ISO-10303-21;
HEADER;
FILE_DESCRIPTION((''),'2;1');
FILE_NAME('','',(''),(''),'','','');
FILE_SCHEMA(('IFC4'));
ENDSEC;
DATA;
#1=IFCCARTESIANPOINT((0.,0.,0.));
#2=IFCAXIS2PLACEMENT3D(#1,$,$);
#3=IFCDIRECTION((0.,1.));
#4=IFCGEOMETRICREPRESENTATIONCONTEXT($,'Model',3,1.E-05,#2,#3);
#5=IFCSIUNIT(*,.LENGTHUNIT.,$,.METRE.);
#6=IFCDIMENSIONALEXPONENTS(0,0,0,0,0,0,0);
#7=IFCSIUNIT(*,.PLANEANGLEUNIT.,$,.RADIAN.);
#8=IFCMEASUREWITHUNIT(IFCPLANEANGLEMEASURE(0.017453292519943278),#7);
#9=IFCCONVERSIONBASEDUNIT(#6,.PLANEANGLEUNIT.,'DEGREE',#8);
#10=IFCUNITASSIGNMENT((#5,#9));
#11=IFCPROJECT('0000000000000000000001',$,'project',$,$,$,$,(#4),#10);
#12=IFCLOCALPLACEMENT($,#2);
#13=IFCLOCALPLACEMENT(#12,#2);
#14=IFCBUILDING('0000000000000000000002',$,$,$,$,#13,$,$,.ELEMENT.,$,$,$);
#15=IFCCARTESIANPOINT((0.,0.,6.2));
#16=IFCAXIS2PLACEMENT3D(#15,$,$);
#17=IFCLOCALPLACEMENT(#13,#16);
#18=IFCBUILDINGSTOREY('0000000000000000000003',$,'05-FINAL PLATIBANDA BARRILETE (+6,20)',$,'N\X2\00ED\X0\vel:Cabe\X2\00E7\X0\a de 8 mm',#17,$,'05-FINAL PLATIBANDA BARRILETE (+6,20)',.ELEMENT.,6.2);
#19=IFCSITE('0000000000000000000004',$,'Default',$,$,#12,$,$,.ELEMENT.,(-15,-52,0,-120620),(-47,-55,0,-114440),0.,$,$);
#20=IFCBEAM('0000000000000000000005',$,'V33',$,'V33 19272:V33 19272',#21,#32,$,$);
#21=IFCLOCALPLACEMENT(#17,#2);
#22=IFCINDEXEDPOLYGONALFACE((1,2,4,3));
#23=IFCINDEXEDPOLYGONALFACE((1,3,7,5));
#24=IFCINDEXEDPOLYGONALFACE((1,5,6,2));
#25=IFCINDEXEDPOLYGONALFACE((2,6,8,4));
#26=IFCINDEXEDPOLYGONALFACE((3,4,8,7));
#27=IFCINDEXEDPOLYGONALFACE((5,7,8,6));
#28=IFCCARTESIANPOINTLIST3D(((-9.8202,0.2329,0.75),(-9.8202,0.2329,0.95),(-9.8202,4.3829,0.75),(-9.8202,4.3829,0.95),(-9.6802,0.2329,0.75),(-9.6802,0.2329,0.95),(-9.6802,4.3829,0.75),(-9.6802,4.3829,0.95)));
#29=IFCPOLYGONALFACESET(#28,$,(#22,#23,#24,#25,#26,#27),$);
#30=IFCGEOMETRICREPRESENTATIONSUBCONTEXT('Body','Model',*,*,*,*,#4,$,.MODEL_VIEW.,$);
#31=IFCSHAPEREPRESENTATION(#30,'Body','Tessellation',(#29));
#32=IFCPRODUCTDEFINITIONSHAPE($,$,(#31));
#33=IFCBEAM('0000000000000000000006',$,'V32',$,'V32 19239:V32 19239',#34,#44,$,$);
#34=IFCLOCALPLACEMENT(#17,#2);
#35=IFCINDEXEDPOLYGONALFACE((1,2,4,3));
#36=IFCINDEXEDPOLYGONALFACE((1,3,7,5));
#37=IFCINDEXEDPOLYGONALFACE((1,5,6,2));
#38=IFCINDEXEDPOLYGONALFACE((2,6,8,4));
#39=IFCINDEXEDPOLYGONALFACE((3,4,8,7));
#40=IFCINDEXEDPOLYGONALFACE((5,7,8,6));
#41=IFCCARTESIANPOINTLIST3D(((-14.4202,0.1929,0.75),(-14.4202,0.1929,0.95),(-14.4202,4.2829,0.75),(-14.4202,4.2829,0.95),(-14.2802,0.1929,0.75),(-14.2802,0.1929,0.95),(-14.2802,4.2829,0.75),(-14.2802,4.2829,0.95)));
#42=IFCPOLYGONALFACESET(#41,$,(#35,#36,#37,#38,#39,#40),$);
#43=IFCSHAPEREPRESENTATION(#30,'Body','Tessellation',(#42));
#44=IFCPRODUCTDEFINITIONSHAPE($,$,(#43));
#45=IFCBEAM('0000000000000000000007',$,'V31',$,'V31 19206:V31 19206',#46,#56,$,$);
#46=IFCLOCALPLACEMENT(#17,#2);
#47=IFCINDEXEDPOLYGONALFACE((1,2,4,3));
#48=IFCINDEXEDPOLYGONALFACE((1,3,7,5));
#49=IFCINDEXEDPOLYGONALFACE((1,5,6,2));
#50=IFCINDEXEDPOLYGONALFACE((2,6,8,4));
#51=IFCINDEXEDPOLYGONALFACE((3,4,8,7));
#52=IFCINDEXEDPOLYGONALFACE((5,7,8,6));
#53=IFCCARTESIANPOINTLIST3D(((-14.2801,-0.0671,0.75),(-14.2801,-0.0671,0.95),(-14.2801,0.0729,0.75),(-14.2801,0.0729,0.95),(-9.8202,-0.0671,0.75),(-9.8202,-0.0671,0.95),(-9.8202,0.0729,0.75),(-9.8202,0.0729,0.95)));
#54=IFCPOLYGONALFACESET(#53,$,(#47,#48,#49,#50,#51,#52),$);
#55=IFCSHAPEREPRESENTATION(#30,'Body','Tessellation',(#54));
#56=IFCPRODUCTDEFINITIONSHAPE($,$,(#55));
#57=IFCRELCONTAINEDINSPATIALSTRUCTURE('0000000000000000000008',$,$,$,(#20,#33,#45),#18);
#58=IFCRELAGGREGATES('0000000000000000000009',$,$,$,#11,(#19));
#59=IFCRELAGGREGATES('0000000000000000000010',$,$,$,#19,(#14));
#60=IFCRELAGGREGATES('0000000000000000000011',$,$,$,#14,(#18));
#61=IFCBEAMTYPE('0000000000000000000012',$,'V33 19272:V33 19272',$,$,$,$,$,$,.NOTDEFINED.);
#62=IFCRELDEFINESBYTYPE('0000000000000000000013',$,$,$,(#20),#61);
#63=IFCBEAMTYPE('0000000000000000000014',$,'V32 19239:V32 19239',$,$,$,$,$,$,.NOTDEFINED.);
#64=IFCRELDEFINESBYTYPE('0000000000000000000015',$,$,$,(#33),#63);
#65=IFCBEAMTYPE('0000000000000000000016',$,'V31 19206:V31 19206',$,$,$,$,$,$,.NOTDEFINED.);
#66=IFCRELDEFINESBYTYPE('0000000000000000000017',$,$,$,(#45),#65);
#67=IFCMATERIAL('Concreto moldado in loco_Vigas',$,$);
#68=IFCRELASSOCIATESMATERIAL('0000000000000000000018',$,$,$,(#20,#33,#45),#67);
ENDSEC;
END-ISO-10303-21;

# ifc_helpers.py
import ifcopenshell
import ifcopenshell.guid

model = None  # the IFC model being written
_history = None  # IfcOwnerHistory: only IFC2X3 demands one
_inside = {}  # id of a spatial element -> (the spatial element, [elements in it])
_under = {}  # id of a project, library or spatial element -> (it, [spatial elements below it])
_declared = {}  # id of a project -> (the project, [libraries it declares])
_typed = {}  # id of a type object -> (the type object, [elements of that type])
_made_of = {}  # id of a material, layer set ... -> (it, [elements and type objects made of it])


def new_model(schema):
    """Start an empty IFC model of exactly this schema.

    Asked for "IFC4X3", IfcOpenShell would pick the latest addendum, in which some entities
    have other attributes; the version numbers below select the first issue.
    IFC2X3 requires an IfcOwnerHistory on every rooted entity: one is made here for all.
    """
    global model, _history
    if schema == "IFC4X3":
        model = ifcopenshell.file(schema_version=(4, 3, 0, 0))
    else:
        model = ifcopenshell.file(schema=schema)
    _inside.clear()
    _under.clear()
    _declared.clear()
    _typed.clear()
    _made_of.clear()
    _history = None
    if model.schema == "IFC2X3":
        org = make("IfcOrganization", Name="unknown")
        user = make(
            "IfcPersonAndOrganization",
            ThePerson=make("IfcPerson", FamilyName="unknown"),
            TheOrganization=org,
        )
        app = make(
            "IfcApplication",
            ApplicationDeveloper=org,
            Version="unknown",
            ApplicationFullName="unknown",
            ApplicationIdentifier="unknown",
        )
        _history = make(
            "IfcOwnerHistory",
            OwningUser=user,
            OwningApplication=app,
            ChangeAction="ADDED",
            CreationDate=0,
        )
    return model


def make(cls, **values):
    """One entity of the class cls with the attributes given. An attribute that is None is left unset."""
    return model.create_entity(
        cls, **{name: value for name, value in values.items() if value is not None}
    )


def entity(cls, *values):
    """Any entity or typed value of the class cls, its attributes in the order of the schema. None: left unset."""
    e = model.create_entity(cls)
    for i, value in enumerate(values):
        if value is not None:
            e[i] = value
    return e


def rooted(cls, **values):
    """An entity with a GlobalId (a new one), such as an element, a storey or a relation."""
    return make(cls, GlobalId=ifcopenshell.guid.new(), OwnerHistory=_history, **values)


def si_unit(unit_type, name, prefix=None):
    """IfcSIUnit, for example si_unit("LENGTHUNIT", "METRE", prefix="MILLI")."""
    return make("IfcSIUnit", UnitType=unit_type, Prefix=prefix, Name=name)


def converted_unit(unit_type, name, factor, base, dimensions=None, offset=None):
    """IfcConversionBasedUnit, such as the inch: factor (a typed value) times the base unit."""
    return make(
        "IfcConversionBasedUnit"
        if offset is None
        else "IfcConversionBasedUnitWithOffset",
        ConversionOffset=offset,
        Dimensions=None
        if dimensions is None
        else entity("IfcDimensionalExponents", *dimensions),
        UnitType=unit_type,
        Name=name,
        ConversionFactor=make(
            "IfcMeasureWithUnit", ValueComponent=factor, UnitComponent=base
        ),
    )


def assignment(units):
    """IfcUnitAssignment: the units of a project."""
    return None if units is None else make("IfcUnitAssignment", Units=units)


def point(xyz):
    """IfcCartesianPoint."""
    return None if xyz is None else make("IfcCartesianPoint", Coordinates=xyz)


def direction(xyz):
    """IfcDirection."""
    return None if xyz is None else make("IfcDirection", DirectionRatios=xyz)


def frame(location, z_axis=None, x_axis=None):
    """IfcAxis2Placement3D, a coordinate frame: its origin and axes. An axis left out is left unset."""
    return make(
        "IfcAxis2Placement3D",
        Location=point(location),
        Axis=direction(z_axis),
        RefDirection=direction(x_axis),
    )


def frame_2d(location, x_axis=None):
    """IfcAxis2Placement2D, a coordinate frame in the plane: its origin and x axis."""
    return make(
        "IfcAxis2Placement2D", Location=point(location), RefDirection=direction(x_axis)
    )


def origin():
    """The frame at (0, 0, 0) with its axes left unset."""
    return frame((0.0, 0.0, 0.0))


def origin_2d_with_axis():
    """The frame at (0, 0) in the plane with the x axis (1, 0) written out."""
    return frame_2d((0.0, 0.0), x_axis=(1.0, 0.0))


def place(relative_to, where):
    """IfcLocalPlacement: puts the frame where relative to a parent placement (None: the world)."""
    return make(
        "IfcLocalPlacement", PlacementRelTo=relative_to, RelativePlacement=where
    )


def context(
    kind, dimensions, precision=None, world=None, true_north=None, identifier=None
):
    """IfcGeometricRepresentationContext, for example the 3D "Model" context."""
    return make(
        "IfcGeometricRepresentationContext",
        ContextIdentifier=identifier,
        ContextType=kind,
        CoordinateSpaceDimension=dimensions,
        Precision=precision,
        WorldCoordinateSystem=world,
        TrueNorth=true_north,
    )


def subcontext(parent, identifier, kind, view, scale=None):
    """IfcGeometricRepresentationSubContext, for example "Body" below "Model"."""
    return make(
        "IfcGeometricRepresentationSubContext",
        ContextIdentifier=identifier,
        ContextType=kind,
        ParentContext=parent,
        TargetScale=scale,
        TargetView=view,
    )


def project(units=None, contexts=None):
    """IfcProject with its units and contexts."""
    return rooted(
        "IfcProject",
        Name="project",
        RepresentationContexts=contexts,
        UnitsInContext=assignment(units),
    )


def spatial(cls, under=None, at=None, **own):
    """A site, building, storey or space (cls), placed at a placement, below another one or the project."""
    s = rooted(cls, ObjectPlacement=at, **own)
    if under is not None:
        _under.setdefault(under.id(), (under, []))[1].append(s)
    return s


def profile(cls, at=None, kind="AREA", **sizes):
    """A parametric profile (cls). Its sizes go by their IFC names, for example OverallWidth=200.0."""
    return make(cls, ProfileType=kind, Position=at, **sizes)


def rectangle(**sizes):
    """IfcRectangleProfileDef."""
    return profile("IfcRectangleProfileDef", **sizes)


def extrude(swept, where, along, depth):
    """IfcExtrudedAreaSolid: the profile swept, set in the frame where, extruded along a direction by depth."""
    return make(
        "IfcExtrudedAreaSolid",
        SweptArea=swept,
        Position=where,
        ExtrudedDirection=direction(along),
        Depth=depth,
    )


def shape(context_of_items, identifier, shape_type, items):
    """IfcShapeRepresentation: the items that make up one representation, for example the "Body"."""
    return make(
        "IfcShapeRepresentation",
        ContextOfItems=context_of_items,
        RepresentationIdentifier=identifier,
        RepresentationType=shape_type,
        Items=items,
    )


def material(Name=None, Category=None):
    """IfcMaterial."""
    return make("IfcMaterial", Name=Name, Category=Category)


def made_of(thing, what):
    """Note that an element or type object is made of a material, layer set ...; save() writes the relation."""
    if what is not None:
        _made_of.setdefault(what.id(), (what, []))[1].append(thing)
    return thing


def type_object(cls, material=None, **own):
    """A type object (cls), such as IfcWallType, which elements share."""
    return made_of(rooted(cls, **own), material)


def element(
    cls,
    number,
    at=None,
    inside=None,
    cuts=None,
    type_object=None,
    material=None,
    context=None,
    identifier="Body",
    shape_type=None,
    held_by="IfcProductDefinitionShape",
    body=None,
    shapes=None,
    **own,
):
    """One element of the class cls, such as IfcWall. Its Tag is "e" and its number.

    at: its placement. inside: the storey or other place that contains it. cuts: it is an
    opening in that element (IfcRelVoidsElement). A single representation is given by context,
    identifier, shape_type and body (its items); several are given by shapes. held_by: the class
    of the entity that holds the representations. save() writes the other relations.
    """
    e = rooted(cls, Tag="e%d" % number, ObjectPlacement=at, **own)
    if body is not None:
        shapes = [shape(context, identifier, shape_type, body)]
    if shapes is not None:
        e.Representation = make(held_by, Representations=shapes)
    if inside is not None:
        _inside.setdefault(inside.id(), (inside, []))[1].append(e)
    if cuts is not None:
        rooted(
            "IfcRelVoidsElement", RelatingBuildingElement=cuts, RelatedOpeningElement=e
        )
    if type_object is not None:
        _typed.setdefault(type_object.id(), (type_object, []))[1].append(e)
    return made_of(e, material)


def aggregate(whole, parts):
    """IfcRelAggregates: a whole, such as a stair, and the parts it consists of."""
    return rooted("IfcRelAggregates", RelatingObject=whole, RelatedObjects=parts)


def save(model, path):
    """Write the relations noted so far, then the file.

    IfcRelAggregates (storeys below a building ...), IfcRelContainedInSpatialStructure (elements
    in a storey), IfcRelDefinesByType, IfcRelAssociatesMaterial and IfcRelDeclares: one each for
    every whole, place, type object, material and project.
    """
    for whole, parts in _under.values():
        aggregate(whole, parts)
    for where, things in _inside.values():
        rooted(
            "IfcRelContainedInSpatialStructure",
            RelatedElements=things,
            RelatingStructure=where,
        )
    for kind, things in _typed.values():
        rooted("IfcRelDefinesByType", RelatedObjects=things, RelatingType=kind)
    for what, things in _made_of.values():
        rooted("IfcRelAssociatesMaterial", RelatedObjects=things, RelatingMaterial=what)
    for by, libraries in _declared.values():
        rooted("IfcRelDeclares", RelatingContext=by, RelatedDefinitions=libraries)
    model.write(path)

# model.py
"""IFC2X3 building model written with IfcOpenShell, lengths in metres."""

from ifc_helpers import new_model, entity, si_unit, converted_unit, direction, frame, frame_2d, origin, origin_2d_with_axis, place, context, subcontext, project, spatial, rectangle, extrude, material, type_object, element, save


model = new_model("IFC2X3")

# Units and contexts
model_context = context("Model", 3, precision=1e-05, world=origin(), true_north=direction((0.0, 1.0)))
body_context = subcontext(model_context, "Body", "Model", "MODEL_VIEW")
ifc_project = project(units=[si_unit("LENGTHUNIT", "METRE"), converted_unit("PLANEANGLEUNIT", "DEGREE", entity("IfcPlaneAngleMeasure", 0.017453292519943278), si_unit("PLANEANGLEUNIT", "RADIAN"), dimensions=[0, 0, 0, 0, 0, 0, 0])], contexts=[model_context])

# Site, building, storey
site_placement = place(None, origin())
site = spatial("IfcSite", under=ifc_project, at=site_placement, Name="Default", CompositionType="ELEMENT", RefLatitude=(-15, -52, 0, -120620), RefLongitude=(-47, -55, 0, -114440), RefElevation=0.0)
building_placement = place(site_placement, origin())
building = spatial("IfcBuilding", under=site, at=building_placement, CompositionType="ELEMENT")
storey_placement = place(building_placement, frame((0.0, 0.0, 6.2)))
storey = spatial("IfcBuildingStorey", under=building, at=storey_placement, Name="05-FINAL PLATIBANDA BARRILETE (+6,20)", ObjectType="Nível:Cabeça de 8 mm", LongName="05-FINAL PLATIBANDA BARRILETE (+6,20)", CompositionType="ELEMENT", Elevation=6.2)

# Beams
ifc_material_1 = material(Name="Concreto moldado in loco_Vigas")
beam_type_1 = type_object("IfcBeamType", Name="V33 19272:V33 19272", PredefinedType="NOTDEFINED")
beam_1_placement = place(storey_placement, origin())
element("IfcBeam", 1, at=beam_1_placement, inside=storey, type_object=beam_type_1, material=ifc_material_1, Name="V33", ObjectType="V33 19272:V33 19272", context=body_context, shape_type="SweptSolid", body=[
    extrude(rectangle(XDim=0.2, YDim=4.15, at=frame_2d((0.0, 0.0), x_axis=(0.0, 1.0))), frame((-9.8202, 2.3079, 0.85), z_axis=(1.0, 0.0, 0.0), x_axis=(0.0, -1.0, 0.0)), (0.0, 0.0, 1.0), 0.14),
])
beam_type_2 = type_object("IfcBeamType", Name="V32 19239:V32 19239", PredefinedType="NOTDEFINED")
beam_2_placement = place(storey_placement, origin())
element("IfcBeam", 2, at=beam_2_placement, inside=storey, type_object=beam_type_2, material=ifc_material_1, Name="V32", ObjectType="V32 19239:V32 19239", context=body_context, shape_type="SweptSolid", body=[
    extrude(rectangle(XDim=0.2, YDim=4.09, at=frame_2d((0.0, 0.0), x_axis=(0.0, 1.0))), frame((-14.4202, 2.2379, 0.85), z_axis=(1.0, 0.0, 0.0), x_axis=(0.0, -1.0, 0.0)), (0.0, 0.0, 1.0), 0.14),
])
beam_type_3 = type_object("IfcBeamType", Name="V31 19206:V31 19206", PredefinedType="NOTDEFINED")
beam_3_placement = place(storey_placement, origin())
element("IfcBeam", 3, at=beam_3_placement, inside=storey, type_object=beam_type_3, material=ifc_material_1, Name="V31", ObjectType="V31 19206:V31 19206", context=body_context, shape_type="SweptSolid", body=[
    extrude(rectangle(XDim=0.2, YDim=0.14, at=origin_2d_with_axis()), frame((-14.2801, 0.0029, 0.85), z_axis=(1.0, 0.0, 0.0), x_axis=(0.0, 0.0, -1.0)), (0.0, 0.0, 1.0), 4.4599),
])

save(model, "model.ifc")
